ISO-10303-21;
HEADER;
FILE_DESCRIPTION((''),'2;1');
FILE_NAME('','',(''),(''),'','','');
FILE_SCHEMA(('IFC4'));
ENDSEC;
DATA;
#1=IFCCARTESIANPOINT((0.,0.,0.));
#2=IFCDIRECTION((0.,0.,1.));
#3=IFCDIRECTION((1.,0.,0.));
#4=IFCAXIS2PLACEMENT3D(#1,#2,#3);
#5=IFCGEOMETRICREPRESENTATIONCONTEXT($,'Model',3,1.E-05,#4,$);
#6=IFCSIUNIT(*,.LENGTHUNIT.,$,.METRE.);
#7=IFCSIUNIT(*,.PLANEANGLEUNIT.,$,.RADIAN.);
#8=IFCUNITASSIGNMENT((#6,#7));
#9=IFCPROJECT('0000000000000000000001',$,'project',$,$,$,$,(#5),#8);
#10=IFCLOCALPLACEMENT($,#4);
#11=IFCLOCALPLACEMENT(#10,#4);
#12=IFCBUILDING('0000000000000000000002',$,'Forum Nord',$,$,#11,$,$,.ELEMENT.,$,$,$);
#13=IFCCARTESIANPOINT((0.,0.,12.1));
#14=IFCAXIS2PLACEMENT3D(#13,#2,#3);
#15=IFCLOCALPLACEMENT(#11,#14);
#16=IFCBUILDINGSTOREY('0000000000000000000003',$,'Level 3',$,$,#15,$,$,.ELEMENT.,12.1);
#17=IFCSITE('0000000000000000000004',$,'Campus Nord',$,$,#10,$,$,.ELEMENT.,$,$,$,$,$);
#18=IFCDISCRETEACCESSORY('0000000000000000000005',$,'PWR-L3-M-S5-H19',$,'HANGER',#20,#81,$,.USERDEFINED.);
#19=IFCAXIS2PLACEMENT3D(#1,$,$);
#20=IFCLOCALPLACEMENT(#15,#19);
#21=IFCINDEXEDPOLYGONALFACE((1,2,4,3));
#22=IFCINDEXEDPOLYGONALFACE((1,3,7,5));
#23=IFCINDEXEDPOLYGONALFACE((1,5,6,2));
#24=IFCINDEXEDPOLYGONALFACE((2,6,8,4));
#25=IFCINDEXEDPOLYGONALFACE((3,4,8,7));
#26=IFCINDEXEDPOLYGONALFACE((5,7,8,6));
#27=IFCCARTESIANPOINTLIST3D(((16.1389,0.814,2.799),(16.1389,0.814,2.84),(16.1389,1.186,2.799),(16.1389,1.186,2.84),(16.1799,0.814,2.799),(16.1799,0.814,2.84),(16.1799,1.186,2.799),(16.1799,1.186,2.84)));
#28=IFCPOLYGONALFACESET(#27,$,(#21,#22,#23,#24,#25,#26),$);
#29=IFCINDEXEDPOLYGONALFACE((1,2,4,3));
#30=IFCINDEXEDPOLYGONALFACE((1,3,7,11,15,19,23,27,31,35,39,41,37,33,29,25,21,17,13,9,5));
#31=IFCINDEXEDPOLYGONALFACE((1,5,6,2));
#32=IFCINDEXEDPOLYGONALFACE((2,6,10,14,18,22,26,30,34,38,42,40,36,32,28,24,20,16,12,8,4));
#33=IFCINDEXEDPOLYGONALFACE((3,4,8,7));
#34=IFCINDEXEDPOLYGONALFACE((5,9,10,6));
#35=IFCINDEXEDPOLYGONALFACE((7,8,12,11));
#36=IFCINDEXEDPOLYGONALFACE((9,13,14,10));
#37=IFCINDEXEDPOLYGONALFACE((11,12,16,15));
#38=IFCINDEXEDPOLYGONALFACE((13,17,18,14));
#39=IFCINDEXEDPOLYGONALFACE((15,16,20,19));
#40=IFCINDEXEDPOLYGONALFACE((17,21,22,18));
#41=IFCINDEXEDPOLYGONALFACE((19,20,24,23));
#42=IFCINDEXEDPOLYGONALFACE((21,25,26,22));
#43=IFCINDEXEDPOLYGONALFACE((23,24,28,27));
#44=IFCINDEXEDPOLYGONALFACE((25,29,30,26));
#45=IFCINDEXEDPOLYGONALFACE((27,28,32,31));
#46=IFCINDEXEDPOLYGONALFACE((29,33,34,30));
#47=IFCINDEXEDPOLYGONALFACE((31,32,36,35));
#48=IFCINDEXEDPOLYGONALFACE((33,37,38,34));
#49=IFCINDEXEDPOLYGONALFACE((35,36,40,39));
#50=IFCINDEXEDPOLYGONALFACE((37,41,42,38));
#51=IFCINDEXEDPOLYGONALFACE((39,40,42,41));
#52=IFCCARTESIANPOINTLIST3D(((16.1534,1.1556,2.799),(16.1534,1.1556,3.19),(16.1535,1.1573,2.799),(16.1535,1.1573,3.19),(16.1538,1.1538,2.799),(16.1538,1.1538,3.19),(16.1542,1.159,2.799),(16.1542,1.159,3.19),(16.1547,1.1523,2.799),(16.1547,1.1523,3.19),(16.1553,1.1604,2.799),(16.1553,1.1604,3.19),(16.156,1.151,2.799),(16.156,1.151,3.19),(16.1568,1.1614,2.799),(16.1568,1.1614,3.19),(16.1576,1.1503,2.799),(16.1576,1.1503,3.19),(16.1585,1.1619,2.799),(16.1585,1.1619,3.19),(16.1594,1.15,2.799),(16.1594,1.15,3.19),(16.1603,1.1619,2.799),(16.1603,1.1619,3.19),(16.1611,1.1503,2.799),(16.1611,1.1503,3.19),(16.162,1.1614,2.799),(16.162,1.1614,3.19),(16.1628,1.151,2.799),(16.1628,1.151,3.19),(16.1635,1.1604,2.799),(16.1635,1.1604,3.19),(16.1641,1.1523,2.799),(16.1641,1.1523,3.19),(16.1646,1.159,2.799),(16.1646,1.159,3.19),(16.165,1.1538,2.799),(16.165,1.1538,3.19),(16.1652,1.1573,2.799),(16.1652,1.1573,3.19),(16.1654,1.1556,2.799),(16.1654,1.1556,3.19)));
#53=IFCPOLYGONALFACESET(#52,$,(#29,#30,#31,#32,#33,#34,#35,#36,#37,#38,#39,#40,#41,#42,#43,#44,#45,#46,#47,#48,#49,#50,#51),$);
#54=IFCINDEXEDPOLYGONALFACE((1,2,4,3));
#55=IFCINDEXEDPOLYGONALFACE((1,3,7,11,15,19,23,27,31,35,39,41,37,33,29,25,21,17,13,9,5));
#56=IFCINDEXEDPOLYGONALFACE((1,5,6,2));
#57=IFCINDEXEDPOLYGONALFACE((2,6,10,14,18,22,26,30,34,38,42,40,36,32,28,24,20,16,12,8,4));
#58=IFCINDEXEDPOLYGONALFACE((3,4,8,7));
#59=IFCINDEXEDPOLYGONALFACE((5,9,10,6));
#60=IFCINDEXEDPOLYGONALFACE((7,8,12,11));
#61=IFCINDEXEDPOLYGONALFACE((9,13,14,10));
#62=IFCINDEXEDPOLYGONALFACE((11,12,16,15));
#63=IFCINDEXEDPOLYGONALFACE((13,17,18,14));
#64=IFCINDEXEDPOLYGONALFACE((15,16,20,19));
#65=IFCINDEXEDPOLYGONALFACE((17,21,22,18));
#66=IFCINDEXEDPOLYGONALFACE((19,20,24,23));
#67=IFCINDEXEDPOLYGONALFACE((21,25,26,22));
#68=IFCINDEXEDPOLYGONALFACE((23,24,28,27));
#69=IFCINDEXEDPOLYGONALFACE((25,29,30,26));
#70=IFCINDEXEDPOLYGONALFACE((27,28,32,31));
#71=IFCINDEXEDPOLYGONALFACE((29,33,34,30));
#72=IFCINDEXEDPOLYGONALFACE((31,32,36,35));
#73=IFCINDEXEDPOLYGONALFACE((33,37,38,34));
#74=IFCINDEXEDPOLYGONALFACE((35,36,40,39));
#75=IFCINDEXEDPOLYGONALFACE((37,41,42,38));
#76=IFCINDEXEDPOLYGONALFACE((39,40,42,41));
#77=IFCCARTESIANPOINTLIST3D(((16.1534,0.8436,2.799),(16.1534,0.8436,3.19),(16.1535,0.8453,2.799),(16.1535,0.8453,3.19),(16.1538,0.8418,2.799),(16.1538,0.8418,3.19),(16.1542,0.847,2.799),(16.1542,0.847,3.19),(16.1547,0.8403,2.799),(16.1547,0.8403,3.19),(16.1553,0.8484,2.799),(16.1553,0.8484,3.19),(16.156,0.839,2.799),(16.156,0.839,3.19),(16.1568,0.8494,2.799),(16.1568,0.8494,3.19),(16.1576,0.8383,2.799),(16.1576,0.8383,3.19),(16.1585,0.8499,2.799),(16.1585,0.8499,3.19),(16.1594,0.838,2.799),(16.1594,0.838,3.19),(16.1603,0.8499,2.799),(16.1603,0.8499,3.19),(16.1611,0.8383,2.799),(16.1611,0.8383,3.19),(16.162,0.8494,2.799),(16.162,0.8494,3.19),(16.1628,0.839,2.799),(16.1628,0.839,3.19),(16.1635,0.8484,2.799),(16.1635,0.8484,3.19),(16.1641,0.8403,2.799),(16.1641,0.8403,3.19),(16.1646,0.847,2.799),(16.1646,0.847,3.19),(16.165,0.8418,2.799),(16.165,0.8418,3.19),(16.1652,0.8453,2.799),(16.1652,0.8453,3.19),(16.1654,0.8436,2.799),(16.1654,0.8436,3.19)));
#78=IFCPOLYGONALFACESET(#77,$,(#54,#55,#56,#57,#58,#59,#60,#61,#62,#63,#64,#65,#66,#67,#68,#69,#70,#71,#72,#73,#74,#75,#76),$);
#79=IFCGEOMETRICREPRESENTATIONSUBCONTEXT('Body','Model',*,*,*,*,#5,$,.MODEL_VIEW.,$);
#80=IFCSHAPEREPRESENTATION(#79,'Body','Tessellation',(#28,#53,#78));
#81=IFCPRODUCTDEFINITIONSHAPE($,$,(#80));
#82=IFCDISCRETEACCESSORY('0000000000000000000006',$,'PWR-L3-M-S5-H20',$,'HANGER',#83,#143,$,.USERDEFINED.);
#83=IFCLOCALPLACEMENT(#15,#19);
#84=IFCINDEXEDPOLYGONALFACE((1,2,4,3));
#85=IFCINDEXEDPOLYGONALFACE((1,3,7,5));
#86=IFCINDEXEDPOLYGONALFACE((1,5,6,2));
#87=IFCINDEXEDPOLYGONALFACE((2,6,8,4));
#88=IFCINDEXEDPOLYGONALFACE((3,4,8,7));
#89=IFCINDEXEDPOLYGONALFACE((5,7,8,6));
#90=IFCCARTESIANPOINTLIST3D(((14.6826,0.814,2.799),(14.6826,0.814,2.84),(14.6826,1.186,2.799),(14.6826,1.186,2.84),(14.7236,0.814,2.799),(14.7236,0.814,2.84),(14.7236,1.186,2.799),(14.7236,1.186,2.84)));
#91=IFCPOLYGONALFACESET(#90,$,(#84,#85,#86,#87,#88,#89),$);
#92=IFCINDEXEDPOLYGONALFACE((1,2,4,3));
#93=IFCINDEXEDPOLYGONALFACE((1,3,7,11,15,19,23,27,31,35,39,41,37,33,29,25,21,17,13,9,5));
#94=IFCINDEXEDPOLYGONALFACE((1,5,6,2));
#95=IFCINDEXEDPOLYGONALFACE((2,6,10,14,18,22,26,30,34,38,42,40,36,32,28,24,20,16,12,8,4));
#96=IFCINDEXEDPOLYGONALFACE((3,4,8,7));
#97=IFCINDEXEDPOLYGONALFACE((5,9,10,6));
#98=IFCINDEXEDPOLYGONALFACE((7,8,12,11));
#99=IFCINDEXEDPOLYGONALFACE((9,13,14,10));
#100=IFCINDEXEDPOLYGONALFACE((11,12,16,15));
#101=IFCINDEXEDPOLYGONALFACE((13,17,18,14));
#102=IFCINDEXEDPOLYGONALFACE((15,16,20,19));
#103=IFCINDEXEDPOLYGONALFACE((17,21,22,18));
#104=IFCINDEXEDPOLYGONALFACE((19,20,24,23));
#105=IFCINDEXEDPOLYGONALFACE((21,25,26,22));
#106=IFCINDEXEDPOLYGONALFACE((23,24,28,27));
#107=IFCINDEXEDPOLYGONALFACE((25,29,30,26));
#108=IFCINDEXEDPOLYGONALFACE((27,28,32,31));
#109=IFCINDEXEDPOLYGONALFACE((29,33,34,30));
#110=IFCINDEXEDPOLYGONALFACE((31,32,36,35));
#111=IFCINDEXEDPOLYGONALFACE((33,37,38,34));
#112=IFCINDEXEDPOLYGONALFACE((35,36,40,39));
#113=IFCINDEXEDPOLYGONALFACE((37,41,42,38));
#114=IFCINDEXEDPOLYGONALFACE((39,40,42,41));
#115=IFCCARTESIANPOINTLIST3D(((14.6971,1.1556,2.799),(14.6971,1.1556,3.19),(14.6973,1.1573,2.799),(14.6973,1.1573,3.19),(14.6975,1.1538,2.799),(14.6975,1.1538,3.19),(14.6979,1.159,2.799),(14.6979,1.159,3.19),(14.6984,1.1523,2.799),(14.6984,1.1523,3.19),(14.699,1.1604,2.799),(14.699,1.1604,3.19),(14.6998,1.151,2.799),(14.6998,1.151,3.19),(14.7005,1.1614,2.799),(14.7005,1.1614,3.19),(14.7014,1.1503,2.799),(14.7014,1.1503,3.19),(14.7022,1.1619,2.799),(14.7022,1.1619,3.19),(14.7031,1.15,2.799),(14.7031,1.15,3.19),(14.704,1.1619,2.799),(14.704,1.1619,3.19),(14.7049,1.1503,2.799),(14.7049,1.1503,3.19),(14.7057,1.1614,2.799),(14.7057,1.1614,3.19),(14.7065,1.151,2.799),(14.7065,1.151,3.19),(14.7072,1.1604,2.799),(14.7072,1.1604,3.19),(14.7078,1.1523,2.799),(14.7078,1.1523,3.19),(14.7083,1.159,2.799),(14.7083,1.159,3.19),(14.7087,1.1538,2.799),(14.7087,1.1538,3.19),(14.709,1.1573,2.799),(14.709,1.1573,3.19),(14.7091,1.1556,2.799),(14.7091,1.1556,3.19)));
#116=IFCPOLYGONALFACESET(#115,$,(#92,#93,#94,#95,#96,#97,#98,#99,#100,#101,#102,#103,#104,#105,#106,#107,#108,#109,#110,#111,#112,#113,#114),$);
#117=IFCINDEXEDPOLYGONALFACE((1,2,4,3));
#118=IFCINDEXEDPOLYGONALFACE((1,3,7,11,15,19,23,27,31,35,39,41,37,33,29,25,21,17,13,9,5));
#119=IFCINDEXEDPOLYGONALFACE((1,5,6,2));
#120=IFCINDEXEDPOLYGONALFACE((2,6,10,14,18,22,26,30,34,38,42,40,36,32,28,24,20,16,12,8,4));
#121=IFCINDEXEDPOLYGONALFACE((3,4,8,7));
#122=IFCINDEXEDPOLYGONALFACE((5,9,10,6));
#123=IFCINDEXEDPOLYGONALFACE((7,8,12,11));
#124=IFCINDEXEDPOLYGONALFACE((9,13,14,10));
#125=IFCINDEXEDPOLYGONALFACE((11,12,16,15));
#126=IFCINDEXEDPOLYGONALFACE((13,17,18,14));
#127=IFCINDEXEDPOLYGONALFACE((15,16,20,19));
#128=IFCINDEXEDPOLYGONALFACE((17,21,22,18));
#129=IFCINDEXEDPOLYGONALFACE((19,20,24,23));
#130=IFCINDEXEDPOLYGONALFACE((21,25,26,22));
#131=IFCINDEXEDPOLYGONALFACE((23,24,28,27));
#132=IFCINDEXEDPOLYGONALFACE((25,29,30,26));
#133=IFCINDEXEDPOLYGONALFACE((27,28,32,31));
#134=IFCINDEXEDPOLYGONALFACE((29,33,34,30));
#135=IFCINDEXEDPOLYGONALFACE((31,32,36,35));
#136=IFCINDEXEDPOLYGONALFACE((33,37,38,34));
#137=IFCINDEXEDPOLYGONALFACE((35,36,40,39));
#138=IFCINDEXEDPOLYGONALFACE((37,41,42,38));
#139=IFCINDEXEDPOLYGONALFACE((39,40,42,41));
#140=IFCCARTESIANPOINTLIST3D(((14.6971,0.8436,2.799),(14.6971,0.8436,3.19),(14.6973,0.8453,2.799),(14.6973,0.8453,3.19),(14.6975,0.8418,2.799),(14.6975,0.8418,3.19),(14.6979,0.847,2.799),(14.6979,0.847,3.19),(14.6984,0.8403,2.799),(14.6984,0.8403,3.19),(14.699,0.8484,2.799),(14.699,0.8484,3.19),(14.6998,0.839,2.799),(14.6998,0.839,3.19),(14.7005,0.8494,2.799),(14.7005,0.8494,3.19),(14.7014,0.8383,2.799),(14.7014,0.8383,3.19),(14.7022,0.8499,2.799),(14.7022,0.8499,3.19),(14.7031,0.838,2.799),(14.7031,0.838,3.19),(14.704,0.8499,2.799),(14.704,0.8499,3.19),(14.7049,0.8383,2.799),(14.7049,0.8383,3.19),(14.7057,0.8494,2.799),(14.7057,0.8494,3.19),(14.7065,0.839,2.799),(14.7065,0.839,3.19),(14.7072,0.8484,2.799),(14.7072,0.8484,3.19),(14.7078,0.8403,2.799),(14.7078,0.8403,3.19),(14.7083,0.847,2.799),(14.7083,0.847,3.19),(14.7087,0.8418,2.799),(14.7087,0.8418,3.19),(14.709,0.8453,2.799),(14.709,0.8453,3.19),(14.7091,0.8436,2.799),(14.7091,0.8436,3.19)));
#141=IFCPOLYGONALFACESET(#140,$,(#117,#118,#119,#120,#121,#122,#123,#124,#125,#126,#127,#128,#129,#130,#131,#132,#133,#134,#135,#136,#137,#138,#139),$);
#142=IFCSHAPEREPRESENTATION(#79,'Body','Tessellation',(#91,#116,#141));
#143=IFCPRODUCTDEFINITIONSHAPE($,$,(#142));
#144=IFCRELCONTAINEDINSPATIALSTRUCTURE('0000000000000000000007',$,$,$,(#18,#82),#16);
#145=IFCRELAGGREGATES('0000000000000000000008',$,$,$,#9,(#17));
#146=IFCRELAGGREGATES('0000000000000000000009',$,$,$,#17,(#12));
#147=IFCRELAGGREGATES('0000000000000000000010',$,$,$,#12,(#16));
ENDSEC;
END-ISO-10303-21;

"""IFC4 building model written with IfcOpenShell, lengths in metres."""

from ifc_helpers import new_model, si_unit, frame, frame_2d, origin_with_axes, origin_2d_with_axis, place, context, subcontext, project, spatial, rectangle, circle, extrude, element, save


model = new_model("IFC4")

# Units and contexts
model_context = context("Model", 3, precision=1e-05, world=origin_with_axes())
body_context = subcontext(model_context, "Body", "Model", "MODEL_VIEW")
ifc_project = project(units=[si_unit("LENGTHUNIT", "METRE"), si_unit("PLANEANGLEUNIT", "RADIAN")], contexts=[model_context])

# Site, building, storey
site_placement = place(None, origin_with_axes())
site = spatial("IfcSite", under=ifc_project, at=site_placement, Name="Campus Nord", CompositionType="ELEMENT")
building_placement = place(site_placement, origin_with_axes())
building = spatial("IfcBuilding", under=site, at=building_placement, Name="Forum Nord", CompositionType="ELEMENT")
storey_placement = place(building_placement, frame((0.0, 0.0, 12.1), z_axis=(0.0, 0.0, 1.0), x_axis=(1.0, 0.0, 0.0)))
storey = spatial("IfcBuildingStorey", under=building, at=storey_placement, Name="Level 3", CompositionType="ELEMENT", Elevation=12.1)

# Discrete accessories
for number, where, z_axis, x_axis, name in (
    (1, (16.1594, 1.0, 2.84), (0.0, 0.0, 1.0), (0.0, -1.0, 0.0), "PWR-L3-M-S5-H19"),
    (2, (14.7031, 1.0, 2.84), (0.0, 0.0, 1.0), (0.0, -1.0, 0.0), "PWR-L3-M-S5-H20"),
):
    element("IfcDiscreteAccessory", number, at=place(storey_placement, frame(where, z_axis=z_axis, x_axis=x_axis)), inside=storey, Name=name, ObjectType="HANGER", PredefinedType="USERDEFINED", context=body_context, shape_type="SweptSolid", body=[
        extrude(rectangle(XDim=0.372, YDim=0.041, at=origin_2d_with_axis()), frame((0.0, 0.0, -0.041), z_axis=(0.0, 0.0, 1.0), x_axis=(1.0, 0.0, 0.0)), (0.0, 0.0, 1.0), 0.041),
        extrude(circle(Radius=0.006, at=frame_2d((-0.156, 0.0), x_axis=(1.0, 0.0))), frame((0.0, 0.0, -0.041), z_axis=(0.0, 0.0, 1.0), x_axis=(1.0, 0.0, 0.0)), (0.0, 0.0, 1.0), 0.391),
        extrude(circle(Radius=0.006, at=frame_2d((0.156, 0.0), x_axis=(1.0, 0.0))), frame((0.0, 0.0, -0.041), z_axis=(0.0, 0.0, 1.0), x_axis=(1.0, 0.0, 0.0)), (0.0, 0.0, 1.0), 0.391),
    ])

save(model, "model.ifc")
